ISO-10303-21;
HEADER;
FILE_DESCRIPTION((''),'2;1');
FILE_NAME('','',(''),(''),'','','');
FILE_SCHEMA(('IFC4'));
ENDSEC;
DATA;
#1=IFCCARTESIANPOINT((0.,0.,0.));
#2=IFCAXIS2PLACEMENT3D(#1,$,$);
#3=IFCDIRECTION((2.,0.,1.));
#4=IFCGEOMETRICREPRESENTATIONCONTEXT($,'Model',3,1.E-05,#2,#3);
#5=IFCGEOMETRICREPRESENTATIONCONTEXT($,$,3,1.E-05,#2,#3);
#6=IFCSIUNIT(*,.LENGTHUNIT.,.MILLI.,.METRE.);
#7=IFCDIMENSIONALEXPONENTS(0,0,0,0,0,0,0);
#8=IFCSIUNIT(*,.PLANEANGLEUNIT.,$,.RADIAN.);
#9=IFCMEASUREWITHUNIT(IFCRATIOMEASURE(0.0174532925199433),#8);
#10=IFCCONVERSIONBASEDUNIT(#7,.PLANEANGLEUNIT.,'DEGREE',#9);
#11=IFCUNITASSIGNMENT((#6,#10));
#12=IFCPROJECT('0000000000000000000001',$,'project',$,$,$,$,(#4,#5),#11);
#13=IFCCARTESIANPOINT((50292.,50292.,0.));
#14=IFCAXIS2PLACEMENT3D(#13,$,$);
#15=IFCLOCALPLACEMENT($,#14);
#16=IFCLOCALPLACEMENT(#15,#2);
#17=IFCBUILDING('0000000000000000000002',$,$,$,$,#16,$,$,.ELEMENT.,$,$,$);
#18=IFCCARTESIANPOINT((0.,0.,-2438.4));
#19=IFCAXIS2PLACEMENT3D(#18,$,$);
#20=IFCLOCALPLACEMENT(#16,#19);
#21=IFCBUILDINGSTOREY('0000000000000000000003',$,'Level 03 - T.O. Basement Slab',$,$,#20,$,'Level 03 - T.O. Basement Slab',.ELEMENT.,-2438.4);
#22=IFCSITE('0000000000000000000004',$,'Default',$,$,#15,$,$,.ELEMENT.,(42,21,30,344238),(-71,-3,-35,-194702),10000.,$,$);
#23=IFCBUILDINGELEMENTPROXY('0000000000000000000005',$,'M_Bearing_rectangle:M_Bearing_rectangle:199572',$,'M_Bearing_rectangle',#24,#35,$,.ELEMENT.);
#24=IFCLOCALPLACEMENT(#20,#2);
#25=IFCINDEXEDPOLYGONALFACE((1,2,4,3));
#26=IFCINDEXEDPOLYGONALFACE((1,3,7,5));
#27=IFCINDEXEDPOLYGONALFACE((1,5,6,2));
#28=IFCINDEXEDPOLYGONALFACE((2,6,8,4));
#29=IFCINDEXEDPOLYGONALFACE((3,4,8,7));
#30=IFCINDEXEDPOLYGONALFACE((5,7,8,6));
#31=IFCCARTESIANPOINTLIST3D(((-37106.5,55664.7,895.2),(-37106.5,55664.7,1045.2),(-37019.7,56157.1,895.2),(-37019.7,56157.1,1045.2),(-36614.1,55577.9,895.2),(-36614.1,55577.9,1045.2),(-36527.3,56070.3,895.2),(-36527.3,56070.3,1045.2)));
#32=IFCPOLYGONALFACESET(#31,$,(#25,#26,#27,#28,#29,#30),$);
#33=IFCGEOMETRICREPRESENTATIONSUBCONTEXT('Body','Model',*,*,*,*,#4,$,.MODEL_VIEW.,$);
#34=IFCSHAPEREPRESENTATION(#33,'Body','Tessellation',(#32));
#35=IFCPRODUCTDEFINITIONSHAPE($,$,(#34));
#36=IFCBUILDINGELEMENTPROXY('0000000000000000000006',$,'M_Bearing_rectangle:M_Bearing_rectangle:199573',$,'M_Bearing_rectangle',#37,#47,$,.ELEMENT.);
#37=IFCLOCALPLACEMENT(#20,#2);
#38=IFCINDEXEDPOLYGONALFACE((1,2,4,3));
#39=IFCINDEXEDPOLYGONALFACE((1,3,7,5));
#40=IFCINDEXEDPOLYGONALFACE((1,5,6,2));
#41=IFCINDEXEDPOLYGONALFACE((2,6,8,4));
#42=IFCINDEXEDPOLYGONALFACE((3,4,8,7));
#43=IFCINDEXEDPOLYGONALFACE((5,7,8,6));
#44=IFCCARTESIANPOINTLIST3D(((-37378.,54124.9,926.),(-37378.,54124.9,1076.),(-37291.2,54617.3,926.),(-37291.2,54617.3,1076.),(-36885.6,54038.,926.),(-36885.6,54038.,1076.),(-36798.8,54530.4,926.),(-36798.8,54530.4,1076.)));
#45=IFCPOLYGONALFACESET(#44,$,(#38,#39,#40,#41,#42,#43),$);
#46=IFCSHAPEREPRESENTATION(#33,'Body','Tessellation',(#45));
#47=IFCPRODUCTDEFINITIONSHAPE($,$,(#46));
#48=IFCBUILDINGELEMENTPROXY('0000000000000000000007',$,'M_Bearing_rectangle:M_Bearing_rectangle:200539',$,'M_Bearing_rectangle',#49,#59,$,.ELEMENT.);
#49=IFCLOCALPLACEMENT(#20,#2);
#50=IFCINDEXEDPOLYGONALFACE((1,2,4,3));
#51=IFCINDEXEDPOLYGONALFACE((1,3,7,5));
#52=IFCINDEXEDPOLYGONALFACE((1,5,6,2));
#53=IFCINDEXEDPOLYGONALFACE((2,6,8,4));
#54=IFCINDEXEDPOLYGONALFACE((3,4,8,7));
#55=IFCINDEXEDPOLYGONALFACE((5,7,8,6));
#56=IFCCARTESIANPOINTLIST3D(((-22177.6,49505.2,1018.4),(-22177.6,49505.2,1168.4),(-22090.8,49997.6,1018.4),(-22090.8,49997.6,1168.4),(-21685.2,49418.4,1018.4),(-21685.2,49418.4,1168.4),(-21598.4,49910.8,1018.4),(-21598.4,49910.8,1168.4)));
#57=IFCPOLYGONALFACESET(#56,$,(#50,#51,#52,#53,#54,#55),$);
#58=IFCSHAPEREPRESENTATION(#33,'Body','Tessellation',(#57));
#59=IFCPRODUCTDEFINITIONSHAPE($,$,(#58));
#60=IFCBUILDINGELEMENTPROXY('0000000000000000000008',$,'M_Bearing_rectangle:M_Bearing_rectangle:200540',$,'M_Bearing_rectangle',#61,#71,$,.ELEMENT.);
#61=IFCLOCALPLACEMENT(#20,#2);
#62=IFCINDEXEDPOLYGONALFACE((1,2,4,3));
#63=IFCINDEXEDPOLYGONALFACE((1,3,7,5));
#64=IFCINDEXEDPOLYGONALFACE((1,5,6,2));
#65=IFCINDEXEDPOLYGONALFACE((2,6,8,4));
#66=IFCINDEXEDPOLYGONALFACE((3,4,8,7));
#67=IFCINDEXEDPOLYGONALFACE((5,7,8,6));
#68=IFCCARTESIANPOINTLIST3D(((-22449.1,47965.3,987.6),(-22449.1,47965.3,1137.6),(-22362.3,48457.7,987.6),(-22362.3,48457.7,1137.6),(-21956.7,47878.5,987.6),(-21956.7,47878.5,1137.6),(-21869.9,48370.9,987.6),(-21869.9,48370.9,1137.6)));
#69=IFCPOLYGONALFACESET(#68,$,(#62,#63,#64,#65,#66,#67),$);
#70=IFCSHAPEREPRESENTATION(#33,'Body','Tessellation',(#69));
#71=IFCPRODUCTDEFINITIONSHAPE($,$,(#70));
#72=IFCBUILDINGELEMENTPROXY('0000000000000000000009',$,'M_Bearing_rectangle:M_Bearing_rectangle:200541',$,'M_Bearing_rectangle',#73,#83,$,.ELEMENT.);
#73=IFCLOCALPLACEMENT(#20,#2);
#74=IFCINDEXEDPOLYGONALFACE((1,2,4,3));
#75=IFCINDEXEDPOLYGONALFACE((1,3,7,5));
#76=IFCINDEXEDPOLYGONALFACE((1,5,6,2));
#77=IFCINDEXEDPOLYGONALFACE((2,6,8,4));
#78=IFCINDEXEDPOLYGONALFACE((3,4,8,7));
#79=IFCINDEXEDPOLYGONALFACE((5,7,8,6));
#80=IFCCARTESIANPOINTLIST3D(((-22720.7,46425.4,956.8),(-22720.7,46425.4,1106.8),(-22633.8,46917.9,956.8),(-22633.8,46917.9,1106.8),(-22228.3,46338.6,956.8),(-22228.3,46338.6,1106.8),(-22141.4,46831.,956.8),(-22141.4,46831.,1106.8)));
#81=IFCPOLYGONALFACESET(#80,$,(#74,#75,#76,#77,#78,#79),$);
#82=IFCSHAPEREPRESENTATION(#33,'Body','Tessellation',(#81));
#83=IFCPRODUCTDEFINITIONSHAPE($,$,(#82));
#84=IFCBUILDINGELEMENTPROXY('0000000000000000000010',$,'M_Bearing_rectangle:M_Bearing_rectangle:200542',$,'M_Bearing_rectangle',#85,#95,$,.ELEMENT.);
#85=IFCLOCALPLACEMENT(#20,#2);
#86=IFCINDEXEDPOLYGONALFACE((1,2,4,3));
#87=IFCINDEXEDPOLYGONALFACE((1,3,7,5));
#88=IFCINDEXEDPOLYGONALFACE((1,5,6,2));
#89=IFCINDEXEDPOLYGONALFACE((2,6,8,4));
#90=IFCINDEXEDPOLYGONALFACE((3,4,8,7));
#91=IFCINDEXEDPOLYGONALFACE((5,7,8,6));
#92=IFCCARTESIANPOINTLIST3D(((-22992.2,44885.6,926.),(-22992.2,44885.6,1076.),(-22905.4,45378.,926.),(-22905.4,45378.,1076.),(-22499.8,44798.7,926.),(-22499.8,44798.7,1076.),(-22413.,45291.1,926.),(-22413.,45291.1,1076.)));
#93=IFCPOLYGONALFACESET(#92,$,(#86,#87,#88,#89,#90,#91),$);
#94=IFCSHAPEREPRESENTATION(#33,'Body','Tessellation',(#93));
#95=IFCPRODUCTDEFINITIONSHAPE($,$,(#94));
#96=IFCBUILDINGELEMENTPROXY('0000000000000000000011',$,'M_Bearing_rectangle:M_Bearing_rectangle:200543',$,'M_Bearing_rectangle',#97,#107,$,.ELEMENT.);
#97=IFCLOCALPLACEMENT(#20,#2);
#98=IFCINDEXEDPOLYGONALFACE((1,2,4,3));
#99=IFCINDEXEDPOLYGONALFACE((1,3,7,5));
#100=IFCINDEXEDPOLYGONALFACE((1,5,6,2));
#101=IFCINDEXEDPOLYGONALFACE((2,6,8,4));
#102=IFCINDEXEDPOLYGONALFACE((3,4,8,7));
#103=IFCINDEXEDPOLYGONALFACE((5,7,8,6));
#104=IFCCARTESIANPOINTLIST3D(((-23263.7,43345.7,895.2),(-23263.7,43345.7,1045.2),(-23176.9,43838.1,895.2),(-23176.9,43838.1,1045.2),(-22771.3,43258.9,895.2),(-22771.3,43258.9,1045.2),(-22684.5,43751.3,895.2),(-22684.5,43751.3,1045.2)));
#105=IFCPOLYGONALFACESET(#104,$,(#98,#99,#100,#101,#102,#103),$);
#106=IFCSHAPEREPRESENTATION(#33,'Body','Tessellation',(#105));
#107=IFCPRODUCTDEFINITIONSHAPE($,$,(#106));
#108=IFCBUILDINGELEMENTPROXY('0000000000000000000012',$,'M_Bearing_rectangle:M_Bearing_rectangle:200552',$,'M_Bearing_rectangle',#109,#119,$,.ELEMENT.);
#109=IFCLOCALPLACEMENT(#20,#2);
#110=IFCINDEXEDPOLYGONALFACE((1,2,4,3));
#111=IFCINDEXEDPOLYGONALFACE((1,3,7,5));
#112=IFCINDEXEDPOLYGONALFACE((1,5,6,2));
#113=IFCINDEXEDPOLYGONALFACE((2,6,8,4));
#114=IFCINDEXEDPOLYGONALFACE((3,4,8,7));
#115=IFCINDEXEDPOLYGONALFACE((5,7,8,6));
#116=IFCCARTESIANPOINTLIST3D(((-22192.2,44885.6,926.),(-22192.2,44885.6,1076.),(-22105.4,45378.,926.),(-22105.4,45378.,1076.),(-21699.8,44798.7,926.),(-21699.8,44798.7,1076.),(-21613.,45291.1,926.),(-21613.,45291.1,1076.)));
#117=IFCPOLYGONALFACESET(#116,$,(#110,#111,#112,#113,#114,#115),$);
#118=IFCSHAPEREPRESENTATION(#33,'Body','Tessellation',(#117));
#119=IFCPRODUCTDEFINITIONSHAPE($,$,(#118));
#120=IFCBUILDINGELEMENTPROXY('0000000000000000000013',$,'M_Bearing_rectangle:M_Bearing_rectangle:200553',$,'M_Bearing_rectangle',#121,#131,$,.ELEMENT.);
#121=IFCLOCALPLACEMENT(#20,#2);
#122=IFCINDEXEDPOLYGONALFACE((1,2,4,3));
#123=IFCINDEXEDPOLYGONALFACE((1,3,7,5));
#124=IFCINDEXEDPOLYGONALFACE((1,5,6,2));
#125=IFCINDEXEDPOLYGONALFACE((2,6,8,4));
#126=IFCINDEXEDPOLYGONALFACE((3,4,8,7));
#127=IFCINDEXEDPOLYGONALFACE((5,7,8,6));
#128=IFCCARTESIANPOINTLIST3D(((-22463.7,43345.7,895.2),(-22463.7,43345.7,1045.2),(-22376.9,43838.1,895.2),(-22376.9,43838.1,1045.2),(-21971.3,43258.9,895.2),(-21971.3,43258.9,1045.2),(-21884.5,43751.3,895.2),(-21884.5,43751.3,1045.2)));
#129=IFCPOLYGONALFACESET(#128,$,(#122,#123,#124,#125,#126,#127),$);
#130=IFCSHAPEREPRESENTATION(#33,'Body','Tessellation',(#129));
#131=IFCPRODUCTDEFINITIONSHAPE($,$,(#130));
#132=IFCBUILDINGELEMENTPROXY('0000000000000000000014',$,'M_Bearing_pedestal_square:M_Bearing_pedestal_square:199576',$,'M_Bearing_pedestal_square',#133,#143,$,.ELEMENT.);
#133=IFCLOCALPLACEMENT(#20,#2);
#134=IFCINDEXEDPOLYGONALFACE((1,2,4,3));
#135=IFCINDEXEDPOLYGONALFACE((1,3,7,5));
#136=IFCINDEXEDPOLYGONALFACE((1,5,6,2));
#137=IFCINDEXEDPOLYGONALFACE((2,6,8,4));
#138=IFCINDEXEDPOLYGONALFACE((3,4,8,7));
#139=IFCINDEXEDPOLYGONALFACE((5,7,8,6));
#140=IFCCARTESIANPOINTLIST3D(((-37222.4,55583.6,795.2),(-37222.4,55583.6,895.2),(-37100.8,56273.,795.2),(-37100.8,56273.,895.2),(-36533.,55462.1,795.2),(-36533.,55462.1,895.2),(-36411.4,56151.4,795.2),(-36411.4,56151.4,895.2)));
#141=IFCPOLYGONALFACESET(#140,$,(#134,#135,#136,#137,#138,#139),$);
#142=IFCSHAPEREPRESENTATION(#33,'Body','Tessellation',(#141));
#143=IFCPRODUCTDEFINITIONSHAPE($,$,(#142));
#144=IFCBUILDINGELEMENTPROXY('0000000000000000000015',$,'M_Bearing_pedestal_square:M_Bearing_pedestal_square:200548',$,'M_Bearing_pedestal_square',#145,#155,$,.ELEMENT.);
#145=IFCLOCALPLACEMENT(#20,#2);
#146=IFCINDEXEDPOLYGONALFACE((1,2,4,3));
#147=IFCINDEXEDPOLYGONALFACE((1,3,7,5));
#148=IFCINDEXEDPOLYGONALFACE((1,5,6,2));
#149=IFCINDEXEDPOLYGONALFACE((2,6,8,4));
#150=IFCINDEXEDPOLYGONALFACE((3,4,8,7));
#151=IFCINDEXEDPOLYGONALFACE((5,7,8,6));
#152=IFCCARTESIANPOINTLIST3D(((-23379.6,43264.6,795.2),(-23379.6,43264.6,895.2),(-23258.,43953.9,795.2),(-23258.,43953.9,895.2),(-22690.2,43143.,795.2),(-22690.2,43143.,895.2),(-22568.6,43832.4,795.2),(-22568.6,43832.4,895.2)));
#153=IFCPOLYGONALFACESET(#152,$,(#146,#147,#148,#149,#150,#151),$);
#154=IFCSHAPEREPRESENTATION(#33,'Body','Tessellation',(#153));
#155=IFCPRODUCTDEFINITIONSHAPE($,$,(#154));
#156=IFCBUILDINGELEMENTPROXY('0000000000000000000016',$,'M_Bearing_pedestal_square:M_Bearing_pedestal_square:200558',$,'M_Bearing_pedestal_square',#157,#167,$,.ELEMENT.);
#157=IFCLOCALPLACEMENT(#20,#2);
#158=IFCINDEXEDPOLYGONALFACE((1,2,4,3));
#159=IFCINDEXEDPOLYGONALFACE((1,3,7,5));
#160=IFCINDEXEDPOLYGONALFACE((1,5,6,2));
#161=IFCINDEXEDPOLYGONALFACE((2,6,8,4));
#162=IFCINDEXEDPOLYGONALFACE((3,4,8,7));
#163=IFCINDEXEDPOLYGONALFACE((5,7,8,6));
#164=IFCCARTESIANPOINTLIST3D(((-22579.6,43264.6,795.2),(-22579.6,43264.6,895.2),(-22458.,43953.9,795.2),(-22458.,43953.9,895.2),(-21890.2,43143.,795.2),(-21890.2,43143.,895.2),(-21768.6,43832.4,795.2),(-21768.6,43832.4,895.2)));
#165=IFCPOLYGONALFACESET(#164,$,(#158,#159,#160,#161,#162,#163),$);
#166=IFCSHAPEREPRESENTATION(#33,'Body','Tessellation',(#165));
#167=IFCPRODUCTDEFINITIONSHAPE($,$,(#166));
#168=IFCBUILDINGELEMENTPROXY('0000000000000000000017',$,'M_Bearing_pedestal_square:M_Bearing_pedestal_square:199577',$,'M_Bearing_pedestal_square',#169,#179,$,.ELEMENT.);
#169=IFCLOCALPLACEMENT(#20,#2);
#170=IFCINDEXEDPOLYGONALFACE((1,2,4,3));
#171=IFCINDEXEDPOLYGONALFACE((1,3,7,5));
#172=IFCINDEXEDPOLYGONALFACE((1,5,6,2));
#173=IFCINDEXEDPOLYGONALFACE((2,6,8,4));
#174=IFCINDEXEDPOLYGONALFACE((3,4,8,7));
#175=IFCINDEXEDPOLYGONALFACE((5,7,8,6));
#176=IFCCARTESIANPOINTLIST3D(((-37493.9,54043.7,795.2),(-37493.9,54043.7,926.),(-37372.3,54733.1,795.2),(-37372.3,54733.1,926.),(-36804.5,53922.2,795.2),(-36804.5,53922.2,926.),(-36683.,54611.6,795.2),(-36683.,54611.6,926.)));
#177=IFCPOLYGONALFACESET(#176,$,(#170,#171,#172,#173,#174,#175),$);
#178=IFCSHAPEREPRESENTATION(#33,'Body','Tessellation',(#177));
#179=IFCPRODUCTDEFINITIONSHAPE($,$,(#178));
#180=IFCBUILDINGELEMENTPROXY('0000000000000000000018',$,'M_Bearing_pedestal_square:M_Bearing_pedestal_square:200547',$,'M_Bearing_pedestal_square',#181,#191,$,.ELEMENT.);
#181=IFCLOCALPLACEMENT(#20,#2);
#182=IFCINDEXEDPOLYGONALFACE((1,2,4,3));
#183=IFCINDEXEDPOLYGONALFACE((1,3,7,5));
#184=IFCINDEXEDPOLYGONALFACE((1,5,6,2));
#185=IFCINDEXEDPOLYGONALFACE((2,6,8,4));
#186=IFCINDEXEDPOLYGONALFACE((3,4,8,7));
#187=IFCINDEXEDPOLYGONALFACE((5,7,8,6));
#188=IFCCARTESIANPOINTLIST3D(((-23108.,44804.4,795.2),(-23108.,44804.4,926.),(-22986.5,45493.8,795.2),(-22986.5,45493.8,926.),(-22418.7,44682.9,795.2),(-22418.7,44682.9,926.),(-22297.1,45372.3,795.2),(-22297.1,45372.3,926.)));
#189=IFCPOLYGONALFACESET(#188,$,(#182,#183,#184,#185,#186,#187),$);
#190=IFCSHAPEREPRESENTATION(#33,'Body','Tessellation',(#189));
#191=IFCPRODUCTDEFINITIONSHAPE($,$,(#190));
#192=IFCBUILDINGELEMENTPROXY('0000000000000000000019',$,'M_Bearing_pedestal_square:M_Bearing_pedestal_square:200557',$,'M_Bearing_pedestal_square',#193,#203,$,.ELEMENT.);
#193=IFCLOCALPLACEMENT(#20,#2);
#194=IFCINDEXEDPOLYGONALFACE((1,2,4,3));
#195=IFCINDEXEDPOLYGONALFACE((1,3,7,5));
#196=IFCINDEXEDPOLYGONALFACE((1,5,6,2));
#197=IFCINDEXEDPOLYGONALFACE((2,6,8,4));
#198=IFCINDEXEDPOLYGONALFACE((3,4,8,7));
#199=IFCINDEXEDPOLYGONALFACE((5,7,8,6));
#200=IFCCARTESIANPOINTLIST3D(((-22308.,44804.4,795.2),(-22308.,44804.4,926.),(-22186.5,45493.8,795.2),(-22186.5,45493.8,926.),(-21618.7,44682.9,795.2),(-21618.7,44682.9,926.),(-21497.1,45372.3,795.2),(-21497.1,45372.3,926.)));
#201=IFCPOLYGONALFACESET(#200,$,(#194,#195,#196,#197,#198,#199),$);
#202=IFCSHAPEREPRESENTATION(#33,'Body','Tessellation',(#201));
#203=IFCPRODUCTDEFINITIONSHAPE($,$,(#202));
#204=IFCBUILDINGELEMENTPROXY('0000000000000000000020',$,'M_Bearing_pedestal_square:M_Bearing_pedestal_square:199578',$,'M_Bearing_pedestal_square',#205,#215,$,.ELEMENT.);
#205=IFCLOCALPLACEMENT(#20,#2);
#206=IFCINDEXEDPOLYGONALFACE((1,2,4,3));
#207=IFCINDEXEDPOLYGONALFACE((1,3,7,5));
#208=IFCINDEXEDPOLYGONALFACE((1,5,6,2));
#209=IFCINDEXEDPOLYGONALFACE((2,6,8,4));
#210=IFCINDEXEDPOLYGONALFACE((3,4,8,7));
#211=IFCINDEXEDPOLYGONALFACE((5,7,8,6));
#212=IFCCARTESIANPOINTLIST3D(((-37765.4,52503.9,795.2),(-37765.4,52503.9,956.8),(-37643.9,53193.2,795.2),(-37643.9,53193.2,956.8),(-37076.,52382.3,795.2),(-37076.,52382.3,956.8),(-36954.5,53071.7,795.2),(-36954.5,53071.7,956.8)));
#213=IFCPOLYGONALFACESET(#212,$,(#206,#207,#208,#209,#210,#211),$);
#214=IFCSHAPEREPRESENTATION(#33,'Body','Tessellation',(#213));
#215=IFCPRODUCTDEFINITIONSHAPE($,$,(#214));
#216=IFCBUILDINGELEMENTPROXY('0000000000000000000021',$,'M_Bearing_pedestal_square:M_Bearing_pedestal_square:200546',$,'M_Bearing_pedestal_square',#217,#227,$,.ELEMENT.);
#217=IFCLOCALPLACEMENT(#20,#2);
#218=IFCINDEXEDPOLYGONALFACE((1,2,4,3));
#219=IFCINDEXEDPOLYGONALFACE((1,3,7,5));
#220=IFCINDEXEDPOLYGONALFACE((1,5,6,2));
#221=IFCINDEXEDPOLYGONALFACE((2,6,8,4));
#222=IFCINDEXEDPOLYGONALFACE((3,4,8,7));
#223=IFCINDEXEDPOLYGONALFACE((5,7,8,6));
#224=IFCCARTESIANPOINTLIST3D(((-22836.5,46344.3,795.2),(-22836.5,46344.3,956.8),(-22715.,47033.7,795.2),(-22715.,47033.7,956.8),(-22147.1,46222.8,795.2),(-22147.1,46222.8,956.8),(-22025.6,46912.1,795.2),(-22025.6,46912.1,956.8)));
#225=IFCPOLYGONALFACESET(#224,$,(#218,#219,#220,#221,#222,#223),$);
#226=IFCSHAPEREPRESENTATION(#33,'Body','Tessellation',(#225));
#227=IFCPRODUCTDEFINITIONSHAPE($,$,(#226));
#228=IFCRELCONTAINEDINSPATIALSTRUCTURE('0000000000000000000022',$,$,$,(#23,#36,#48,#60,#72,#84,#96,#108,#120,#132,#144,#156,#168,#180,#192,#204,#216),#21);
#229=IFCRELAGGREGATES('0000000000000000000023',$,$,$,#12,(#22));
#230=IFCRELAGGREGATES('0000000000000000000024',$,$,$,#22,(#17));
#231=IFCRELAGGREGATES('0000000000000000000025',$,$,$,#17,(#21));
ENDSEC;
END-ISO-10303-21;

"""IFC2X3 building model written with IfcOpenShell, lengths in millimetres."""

from ifc_helpers import new_model, entity, si_unit, converted_unit, direction, frame, origin, origin_2d_with_axis, place, context, subcontext, project, spatial, rectangle, extrude, source, transform, mapped, element, save


model = new_model("IFC2X3")

# Units and contexts
model_context = context("Model", 3, precision=1e-05, world=origin(), true_north=direction((2.0, 0.0, 1.0)))
context_of_model = context(None, 3, precision=1e-05, world=origin(), true_north=direction((2.0, 0.0, 1.0)))
body_context = subcontext(model_context, "Body", "Model", "MODEL_VIEW")
ifc_project = project(units=[si_unit("LENGTHUNIT", "METRE", prefix="MILLI"), converted_unit("PLANEANGLEUNIT", "DEGREE", entity("IfcRatioMeasure", 0.0174532925199433), si_unit("PLANEANGLEUNIT", "RADIAN"), dimensions=[0, 0, 0, 0, 0, 0, 0])], contexts=[model_context, context_of_model])

# Site, building, storey
site_placement = place(None, frame((50292.0, 50292.0, 0.0)))
site = spatial("IfcSite", under=ifc_project, at=site_placement, Name="Default", CompositionType="ELEMENT", RefLatitude=(42, 21, 30, 344238), RefLongitude=(-71, -3, -35, -194702), RefElevation=10000.0)
building_placement = place(site_placement, origin())
building = spatial("IfcBuilding", under=site, at=building_placement, CompositionType="ELEMENT")
storey_placement = place(building_placement, frame((0.0, 0.0, -2438.4)))
storey = spatial("IfcBuildingStorey", under=building, at=storey_placement, Name="Level 03 - T.O. Basement Slab", LongName="Level 03 - T.O. Basement Slab", CompositionType="ELEMENT", Elevation=-2438.4)

# Building element proxies
shared_shape_1 = source(origin(), body_context, "Body", "SweptSolid", [
    extrude(rectangle(XDim=500.0, YDim=500.0, at=origin_2d_with_axis()), frame((0.0, 0.0, -150.0), z_axis=(0.0, 0.0, 1.0), x_axis=(-1.0, 0.0, 0.0)), (0.0, 0.0, 1.0), 150.0),
])
for number, where, z_axis, x_axis, name in (
    (1, (-36816.9, 55867.5, 1045.2), (0.0, 0.0, 1.0), (0.173648, 0.984808, 0.0), "M_Bearing_rectangle:M_Bearing_rectangle:199572"),
    (2, (-37088.4, 54327.6, 1076.0), (0.0, 0.0, 1.0), (0.173648, 0.984808, 0.0), "M_Bearing_rectangle:M_Bearing_rectangle:199573"),
    (3, (-21888.0, 49708.0, 1168.4), (0.0, 0.0, 1.0), (0.173648, 0.984808, 0.0), "M_Bearing_rectangle:M_Bearing_rectangle:200539"),
    (4, (-22159.5, 48168.1, 1137.6), (0.0, 0.0, 1.0), (0.173648, 0.984808, 0.0), "M_Bearing_rectangle:M_Bearing_rectangle:200540"),
    (5, (-22431.0, 46628.2, 1106.8), (0.0, 0.0, 1.0), (0.173648, 0.984808, 0.0), "M_Bearing_rectangle:M_Bearing_rectangle:200541"),
    (6, (-22702.6, 45088.4, 1076.0), (0.0, 0.0, 1.0), (0.173648, 0.984808, 0.0), "M_Bearing_rectangle:M_Bearing_rectangle:200542"),
    (7, (-22974.1, 43548.5, 1045.2), (0.0, 0.0, 1.0), (0.173648, 0.984808, 0.0), "M_Bearing_rectangle:M_Bearing_rectangle:200543"),
    (8, (-21902.6, 45088.4, 1076.0), (0.0, 0.0, 1.0), (0.173648, 0.984808, 0.0), "M_Bearing_rectangle:M_Bearing_rectangle:200552"),
    (9, (-22174.1, 43548.5, 1045.2), (0.0, 0.0, 1.0), (0.173648, 0.984808, 0.0), "M_Bearing_rectangle:M_Bearing_rectangle:200553"),
):
    element("IfcBuildingElementProxy", number, at=place(storey_placement, frame(where, z_axis=z_axis, x_axis=x_axis)), inside=storey, Name=name, ObjectType="M_Bearing_rectangle", CompositionType="ELEMENT", context=body_context, shape_type="MappedRepresentation", body=[
        mapped(shared_shape_1, transform((0.0, 0.0, 0.0), scale=1.0)),
    ])
shared_shape_2 = source(origin(), body_context, "Body", "SweptSolid", [
    extrude(rectangle(XDim=700.0, YDim=700.0, at=origin_2d_with_axis()), frame((0.0, 0.0, -100.0)), (0.0, 0.0, 1.0), 100.0),
])
for number, where, z_axis, x_axis, name in (
    (10, (-36816.9, 55867.5, 895.2), (0.0, 0.0, 1.0), (0.173648, 0.984808, 0.0), "M_Bearing_pedestal_square:M_Bearing_pedestal_square:199576"),
    (11, (-22974.1, 43548.5, 895.2), (0.0, 0.0, 1.0), (0.173648, 0.984808, 0.0), "M_Bearing_pedestal_square:M_Bearing_pedestal_square:200548"),
    (12, (-22174.1, 43548.5, 895.2), (0.0, 0.0, 1.0), (0.173648, 0.984808, 0.0), "M_Bearing_pedestal_square:M_Bearing_pedestal_square:200558"),
):
    element("IfcBuildingElementProxy", number, at=place(storey_placement, frame(where, z_axis=z_axis, x_axis=x_axis)), inside=storey, Name=name, ObjectType="M_Bearing_pedestal_square", CompositionType="ELEMENT", context=body_context, shape_type="MappedRepresentation", body=[
        mapped(shared_shape_2, transform((0.0, 0.0, 0.0), scale=1.0)),
    ])
shared_shape_3 = source(origin(), body_context, "Body", "SweptSolid", [
    extrude(rectangle(XDim=700.0, YDim=700.0, at=origin_2d_with_axis()), frame((0.0, 0.0, -130.8)), (0.0, 0.0, 1.0), 130.8),
])
for number, where, z_axis, x_axis, name in (
    (13, (-37088.4, 54327.6, 926.0), (0.0, 0.0, 1.0), (0.173648, 0.984808, 0.0), "M_Bearing_pedestal_square:M_Bearing_pedestal_square:199577"),
    (14, (-22702.6, 45088.4, 926.0), (0.0, 0.0, 1.0), (0.173648, 0.984808, 0.0), "M_Bearing_pedestal_square:M_Bearing_pedestal_square:200547"),
    (15, (-21902.6, 45088.4, 926.0), (0.0, 0.0, 1.0), (0.173648, 0.984808, 0.0), "M_Bearing_pedestal_square:M_Bearing_pedestal_square:200557"),
):
    element("IfcBuildingElementProxy", number, at=place(storey_placement, frame(where, z_axis=z_axis, x_axis=x_axis)), inside=storey, Name=name, ObjectType="M_Bearing_pedestal_square", CompositionType="ELEMENT", context=body_context, shape_type="MappedRepresentation", body=[
        mapped(shared_shape_3, transform((0.0, 0.0, 0.0), scale=1.0)),
    ])
shared_shape_4 = source(origin(), body_context, "Body", "SweptSolid", [
    extrude(rectangle(XDim=700.0, YDim=700.0, at=origin_2d_with_axis()), frame((0.0, 0.0, -161.6)), (0.0, 0.0, 1.0), 161.6),
])
for number, where, z_axis, x_axis, name in (
    (16, (-37360.0, 52787.8, 956.8), (0.0, 0.0, 1.0), (0.173648, 0.984808, 0.0), "M_Bearing_pedestal_square:M_Bearing_pedestal_square:199578"),
    (17, (-22431.0, 46628.2, 956.8), (0.0, 0.0, 1.0), (0.173648, 0.984808, 0.0), "M_Bearing_pedestal_square:M_Bearing_pedestal_square:200546"),
):
    element("IfcBuildingElementProxy", number, at=place(storey_placement, frame(where, z_axis=z_axis, x_axis=x_axis)), inside=storey, Name=name, ObjectType="M_Bearing_pedestal_square", CompositionType="ELEMENT", context=body_context, shape_type="MappedRepresentation", body=[
        mapped(shared_shape_4, transform((0.0, 0.0, 0.0), scale=1.0)),
    ])

save(model, "model.ifc")
